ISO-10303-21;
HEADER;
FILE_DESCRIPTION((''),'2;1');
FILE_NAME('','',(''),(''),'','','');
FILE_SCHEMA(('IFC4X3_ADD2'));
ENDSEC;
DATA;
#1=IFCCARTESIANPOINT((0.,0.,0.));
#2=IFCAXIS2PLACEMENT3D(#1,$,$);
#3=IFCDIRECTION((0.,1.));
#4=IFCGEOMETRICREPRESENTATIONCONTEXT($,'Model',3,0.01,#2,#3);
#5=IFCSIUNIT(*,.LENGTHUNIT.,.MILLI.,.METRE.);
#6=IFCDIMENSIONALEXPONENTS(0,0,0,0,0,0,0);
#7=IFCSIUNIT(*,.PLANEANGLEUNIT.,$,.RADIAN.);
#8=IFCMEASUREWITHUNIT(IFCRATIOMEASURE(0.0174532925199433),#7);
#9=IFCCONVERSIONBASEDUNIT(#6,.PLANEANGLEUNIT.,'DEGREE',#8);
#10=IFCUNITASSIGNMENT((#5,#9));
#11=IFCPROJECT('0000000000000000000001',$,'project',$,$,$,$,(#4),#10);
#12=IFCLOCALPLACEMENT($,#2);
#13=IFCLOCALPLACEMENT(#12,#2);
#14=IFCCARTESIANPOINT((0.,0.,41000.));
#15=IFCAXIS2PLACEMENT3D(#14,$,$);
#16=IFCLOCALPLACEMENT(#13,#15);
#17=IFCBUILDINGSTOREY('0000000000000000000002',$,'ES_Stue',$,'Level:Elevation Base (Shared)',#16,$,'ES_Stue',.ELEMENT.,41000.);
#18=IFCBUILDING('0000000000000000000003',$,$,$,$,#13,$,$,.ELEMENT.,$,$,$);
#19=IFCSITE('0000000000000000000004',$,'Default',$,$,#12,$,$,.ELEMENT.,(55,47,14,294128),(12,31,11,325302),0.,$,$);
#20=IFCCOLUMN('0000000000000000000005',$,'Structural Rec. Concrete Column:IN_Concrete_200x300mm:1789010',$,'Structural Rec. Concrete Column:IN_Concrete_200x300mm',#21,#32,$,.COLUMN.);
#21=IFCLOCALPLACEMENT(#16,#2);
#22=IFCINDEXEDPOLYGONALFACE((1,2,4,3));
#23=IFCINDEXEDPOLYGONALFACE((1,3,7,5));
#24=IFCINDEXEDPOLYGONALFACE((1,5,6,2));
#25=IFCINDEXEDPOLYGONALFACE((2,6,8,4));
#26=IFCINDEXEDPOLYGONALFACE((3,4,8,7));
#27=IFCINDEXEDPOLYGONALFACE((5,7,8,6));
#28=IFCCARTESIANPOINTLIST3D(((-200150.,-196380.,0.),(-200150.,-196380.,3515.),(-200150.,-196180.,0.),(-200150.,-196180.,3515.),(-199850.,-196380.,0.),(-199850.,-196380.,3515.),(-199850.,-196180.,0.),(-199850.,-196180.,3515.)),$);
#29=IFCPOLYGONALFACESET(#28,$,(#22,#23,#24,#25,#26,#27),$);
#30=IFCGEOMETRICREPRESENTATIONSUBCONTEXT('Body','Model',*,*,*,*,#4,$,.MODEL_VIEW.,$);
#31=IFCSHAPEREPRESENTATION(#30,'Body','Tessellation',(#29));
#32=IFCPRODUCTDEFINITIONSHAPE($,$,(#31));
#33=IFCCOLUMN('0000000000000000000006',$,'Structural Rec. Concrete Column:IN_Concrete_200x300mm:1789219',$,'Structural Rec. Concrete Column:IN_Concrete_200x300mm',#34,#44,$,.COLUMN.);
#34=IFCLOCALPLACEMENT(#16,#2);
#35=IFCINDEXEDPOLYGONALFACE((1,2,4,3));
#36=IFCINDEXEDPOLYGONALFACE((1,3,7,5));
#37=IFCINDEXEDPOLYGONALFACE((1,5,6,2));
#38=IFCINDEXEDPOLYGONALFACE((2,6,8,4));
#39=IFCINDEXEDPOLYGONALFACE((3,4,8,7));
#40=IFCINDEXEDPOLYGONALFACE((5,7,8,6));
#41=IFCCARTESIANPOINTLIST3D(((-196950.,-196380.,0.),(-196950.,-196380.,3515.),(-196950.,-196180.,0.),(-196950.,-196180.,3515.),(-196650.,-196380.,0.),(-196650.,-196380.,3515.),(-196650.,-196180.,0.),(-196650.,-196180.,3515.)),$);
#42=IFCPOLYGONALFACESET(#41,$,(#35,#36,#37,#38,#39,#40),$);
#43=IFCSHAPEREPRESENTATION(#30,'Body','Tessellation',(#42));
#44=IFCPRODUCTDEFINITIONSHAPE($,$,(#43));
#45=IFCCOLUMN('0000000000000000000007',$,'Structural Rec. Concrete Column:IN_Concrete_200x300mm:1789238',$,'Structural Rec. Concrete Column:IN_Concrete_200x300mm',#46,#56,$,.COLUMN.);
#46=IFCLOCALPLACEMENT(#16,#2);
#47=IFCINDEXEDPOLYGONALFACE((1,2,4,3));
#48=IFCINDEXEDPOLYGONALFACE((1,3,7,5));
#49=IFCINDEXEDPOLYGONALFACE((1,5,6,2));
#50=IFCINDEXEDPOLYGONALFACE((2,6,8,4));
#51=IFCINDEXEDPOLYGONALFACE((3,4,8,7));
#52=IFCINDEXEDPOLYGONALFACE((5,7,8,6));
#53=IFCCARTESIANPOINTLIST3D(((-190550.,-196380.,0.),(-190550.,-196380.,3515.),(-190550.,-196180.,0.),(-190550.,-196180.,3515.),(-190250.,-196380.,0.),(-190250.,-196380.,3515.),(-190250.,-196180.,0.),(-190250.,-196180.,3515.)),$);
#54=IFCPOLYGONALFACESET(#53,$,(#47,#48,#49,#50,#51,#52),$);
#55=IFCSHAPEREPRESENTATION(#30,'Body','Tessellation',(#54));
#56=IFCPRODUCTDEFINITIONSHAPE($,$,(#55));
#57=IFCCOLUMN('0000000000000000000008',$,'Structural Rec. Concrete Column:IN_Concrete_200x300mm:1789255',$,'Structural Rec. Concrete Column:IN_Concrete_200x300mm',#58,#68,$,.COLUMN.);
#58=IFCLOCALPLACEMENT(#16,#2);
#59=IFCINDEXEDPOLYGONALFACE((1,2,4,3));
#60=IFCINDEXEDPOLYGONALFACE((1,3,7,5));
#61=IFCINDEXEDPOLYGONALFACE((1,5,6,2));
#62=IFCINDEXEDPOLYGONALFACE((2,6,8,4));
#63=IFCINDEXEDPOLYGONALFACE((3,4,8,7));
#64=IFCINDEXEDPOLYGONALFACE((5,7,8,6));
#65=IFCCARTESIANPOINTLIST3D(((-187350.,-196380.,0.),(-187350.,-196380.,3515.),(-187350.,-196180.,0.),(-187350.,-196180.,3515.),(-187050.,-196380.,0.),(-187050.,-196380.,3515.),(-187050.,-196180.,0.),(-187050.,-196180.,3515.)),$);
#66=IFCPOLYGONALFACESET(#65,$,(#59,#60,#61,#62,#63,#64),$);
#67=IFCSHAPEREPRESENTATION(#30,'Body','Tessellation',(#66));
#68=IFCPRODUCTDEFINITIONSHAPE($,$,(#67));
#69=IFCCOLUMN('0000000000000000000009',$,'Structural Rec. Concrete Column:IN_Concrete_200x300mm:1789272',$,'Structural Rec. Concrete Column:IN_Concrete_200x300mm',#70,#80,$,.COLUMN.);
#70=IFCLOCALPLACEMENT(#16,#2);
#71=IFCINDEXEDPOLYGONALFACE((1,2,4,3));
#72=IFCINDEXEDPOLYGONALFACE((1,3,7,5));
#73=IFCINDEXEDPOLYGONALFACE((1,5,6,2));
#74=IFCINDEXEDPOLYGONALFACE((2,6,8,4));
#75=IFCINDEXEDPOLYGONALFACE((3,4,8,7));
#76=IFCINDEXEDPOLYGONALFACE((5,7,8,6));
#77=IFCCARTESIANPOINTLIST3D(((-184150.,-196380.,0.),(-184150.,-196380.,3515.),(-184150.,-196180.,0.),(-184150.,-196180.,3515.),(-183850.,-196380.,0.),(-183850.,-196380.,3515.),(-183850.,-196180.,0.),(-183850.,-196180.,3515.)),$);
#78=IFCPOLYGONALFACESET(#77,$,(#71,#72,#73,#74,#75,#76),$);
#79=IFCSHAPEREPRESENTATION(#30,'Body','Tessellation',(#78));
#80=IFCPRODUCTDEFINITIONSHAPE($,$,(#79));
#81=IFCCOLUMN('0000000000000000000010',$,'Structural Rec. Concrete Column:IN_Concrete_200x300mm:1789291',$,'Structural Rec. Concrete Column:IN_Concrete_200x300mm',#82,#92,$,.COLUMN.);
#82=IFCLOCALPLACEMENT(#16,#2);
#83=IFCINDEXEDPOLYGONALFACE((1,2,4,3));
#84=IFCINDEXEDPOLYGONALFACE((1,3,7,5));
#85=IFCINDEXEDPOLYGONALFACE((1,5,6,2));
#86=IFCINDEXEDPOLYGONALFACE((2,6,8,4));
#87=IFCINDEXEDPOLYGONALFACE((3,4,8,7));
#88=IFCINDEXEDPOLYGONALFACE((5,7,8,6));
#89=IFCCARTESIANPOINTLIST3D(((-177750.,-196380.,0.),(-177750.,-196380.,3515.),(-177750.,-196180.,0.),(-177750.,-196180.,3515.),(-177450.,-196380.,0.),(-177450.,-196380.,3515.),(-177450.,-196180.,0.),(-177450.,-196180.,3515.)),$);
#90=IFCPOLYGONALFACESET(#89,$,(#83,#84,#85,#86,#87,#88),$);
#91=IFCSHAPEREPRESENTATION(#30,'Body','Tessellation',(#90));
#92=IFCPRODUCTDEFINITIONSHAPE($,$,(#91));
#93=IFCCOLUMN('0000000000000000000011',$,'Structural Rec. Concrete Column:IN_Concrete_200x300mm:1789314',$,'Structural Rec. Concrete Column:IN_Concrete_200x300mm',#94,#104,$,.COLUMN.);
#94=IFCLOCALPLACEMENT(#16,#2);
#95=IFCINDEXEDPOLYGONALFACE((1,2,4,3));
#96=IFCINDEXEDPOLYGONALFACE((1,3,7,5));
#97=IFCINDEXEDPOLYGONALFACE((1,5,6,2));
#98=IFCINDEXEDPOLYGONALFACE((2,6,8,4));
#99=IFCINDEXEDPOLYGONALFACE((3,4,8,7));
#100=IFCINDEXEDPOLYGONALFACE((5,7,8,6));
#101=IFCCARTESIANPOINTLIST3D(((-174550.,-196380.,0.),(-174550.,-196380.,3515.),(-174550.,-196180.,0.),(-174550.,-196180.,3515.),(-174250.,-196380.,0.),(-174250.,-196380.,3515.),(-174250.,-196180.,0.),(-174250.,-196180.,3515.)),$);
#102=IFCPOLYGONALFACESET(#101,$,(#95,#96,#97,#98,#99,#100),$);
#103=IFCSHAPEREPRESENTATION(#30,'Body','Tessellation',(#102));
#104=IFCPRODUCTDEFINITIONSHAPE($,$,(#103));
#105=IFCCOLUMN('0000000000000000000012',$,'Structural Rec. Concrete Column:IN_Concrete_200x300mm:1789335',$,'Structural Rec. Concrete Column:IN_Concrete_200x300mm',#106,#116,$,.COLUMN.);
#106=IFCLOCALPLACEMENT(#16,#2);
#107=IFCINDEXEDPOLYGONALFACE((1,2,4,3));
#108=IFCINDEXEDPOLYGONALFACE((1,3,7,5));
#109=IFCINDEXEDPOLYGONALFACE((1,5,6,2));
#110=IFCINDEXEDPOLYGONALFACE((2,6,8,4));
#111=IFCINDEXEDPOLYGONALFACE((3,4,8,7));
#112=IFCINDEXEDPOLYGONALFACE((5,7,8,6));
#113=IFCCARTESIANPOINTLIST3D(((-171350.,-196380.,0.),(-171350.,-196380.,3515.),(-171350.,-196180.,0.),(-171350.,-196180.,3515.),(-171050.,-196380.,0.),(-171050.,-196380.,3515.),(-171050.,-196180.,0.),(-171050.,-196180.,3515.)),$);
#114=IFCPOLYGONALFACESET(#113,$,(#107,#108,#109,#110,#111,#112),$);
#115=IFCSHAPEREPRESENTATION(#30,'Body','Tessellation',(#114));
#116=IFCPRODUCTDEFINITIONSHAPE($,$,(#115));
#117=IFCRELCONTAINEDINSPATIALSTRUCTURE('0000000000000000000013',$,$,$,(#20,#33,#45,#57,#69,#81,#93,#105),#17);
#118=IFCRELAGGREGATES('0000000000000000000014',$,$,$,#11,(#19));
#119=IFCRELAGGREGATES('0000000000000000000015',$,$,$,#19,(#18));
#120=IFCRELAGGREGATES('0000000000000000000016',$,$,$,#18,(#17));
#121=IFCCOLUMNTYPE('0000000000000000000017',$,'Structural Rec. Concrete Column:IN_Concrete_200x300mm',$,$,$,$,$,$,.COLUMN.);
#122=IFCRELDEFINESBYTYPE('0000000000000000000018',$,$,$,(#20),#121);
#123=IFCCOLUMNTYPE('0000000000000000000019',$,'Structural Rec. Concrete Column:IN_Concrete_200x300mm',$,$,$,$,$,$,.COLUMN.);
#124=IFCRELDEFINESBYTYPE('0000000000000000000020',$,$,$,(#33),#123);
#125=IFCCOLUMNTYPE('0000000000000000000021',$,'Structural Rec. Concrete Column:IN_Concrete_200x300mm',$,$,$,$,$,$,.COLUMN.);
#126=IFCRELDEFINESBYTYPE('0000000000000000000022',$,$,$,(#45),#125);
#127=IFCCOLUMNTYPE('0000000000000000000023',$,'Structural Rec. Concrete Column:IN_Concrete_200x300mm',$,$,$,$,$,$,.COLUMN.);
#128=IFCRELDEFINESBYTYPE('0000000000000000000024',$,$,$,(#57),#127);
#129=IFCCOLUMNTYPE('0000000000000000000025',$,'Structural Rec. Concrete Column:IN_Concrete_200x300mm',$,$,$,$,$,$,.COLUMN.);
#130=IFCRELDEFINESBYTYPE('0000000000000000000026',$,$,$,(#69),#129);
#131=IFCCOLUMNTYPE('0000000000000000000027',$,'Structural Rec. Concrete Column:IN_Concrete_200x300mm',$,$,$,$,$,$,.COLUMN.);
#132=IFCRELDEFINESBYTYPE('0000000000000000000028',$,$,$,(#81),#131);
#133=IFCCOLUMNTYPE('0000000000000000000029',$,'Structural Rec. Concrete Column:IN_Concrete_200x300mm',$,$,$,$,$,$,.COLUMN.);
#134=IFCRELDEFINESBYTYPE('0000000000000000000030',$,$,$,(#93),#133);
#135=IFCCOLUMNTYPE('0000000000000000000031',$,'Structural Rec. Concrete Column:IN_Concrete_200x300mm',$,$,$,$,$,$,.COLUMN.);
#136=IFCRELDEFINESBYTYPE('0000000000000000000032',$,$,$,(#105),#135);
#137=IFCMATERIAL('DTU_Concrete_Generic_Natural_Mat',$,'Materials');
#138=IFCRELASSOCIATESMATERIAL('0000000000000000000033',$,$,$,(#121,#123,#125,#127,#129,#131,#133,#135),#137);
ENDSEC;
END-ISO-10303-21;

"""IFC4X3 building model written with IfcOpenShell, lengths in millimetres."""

from ifc_helpers import new_model, entity, si_unit, converted_unit, direction, frame, origin, origin_2d_with_axis, place, context, subcontext, project, spatial, rectangle, extrude, source, transform, mapped, material, material_profile, profile_set, type_object, type_shapes, element, save


model = new_model("IFC4X3")

# Units and contexts
model_context = context("Model", 3, precision=0.01, world=origin(), true_north=direction((0.0, 1.0)))
body_context = subcontext(model_context, "Body", "Model", "MODEL_VIEW")
ifc_project = project(units=[si_unit("LENGTHUNIT", "METRE", prefix="MILLI"), converted_unit("PLANEANGLEUNIT", "DEGREE", entity("IfcRatioMeasure", 0.0174532925199433), si_unit("PLANEANGLEUNIT", "RADIAN"), dimensions=[0, 0, 0, 0, 0, 0, 0])], contexts=[model_context])

# Site, building, storey
site_placement = place(None, origin())
site = spatial("IfcSite", under=ifc_project, at=site_placement, Name="Default", CompositionType="ELEMENT", RefLatitude=(55, 47, 14, 294128), RefLongitude=(12, 31, 11, 325302), RefElevation=0.0)
building_placement = place(site_placement, origin())
building = spatial("IfcBuilding", under=site, at=building_placement, CompositionType="ELEMENT")
storey_placement = place(building_placement, frame((0.0, 0.0, 41000.0)))
storey = spatial("IfcBuildingStorey", under=building, at=storey_placement, Name="ES_Stue", ObjectType="Level:Elevation Base (Shared)", LongName="ES_Stue", CompositionType="ELEMENT", Elevation=41000.0)

# Columns
ifc_material = material(Name="DTU_Concrete_Generic_Natural_Mat", Category="Materials")
ifc_material_profile_1 = material_profile(ifc_material, rectangle(XDim=200.0, YDim=300.0, at=origin_2d_with_axis()), Name="IN_Concrete_200x300mm")
ifc_profile_set_1 = profile_set([ifc_material_profile_1], Name="IN_Concrete_200x300mm")
column_type_1 = type_object("IfcColumnType", Name="Structural Rec. Concrete Column:IN_Concrete_200x300mm", PredefinedType="COLUMN", material=ifc_profile_set_1)
shared_shape_1 = source(origin(), body_context, "Body", "SweptSolid", [
    extrude(rectangle(XDim=200.0, YDim=300.0, at=origin_2d_with_axis()), frame((-200000.0, -196280.0, 41000.0), z_axis=(0.0, 0.0, 1.0), x_axis=(0.0, -1.0, 0.0)), (0.0, 0.0, 1.0), 3515.0),
])
type_shapes(column_type_1, [shared_shape_1])
column_1_placement = place(storey_placement, frame((0.0, 0.0, -41000.0)))
element("IfcColumn", 1, at=column_1_placement, inside=storey, type_object=column_type_1, Name="Structural Rec. Concrete Column:IN_Concrete_200x300mm:1789010", ObjectType="Structural Rec. Concrete Column:IN_Concrete_200x300mm", PredefinedType="COLUMN", context=body_context, shape_type="MappedRepresentation", body=[
    mapped(shared_shape_1, transform((0.0, 0.0, 0.0), scale=1.0)),
])
column_type_2 = type_object("IfcColumnType", Name="Structural Rec. Concrete Column:IN_Concrete_200x300mm", PredefinedType="COLUMN", material=ifc_profile_set_1)
shared_shape_2 = source(origin(), body_context, "Body", "SweptSolid", [
    extrude(rectangle(XDim=200.0, YDim=300.0, at=origin_2d_with_axis()), frame((-196800.0, -196280.0, 41000.0), z_axis=(0.0, 0.0, 1.0), x_axis=(0.0, -1.0, 0.0)), (0.0, 0.0, 1.0), 3515.0),
])
type_shapes(column_type_2, [shared_shape_2])
column_2_placement = place(storey_placement, frame((0.0, 0.0, -41000.0)))
element("IfcColumn", 2, at=column_2_placement, inside=storey, type_object=column_type_2, Name="Structural Rec. Concrete Column:IN_Concrete_200x300mm:1789219", ObjectType="Structural Rec. Concrete Column:IN_Concrete_200x300mm", PredefinedType="COLUMN", context=body_context, shape_type="MappedRepresentation", body=[
    mapped(shared_shape_2, transform((0.0, 0.0, 0.0), scale=1.0)),
])
column_type_3 = type_object("IfcColumnType", Name="Structural Rec. Concrete Column:IN_Concrete_200x300mm", PredefinedType="COLUMN", material=ifc_profile_set_1)
shared_shape_3 = source(origin(), body_context, "Body", "SweptSolid", [
    extrude(rectangle(XDim=200.0, YDim=300.0, at=origin_2d_with_axis()), frame((-190400.0, -196280.0, 41000.0), z_axis=(0.0, 0.0, 1.0), x_axis=(0.0, -1.0, 0.0)), (0.0, 0.0, 1.0), 3515.0),
])
type_shapes(column_type_3, [shared_shape_3])
column_3_placement = place(storey_placement, frame((0.0, 0.0, -41000.0)))
element("IfcColumn", 3, at=column_3_placement, inside=storey, type_object=column_type_3, Name="Structural Rec. Concrete Column:IN_Concrete_200x300mm:1789238", ObjectType="Structural Rec. Concrete Column:IN_Concrete_200x300mm", PredefinedType="COLUMN", context=body_context, shape_type="MappedRepresentation", body=[
    mapped(shared_shape_3, transform((0.0, 0.0, 0.0), scale=1.0)),
])
column_type_4 = type_object("IfcColumnType", Name="Structural Rec. Concrete Column:IN_Concrete_200x300mm", PredefinedType="COLUMN", material=ifc_profile_set_1)
shared_shape_4 = source(origin(), body_context, "Body", "SweptSolid", [
    extrude(rectangle(XDim=200.0, YDim=300.0, at=origin_2d_with_axis()), frame((-187200.0, -196280.0, 41000.0), z_axis=(0.0, 0.0, 1.0), x_axis=(0.0, -1.0, 0.0)), (0.0, 0.0, 1.0), 3515.0),
])
type_shapes(column_type_4, [shared_shape_4])
column_4_placement = place(storey_placement, frame((0.0, 0.0, -41000.0)))
element("IfcColumn", 4, at=column_4_placement, inside=storey, type_object=column_type_4, Name="Structural Rec. Concrete Column:IN_Concrete_200x300mm:1789255", ObjectType="Structural Rec. Concrete Column:IN_Concrete_200x300mm", PredefinedType="COLUMN", context=body_context, shape_type="MappedRepresentation", body=[
    mapped(shared_shape_4, transform((0.0, 0.0, 0.0), scale=1.0)),
])
column_type_5 = type_object("IfcColumnType", Name="Structural Rec. Concrete Column:IN_Concrete_200x300mm", PredefinedType="COLUMN", material=ifc_profile_set_1)
shared_shape_5 = source(origin(), body_context, "Body", "SweptSolid", [
    extrude(rectangle(XDim=200.0, YDim=300.0, at=origin_2d_with_axis()), frame((-184000.0, -196280.0, 41000.0), z_axis=(0.0, 0.0, 1.0), x_axis=(0.0, -1.0, 0.0)), (0.0, 0.0, 1.0), 3515.0),
])
type_shapes(column_type_5, [shared_shape_5])
column_5_placement = place(storey_placement, frame((0.0, 0.0, -41000.0)))
element("IfcColumn", 5, at=column_5_placement, inside=storey, type_object=column_type_5, Name="Structural Rec. Concrete Column:IN_Concrete_200x300mm:1789272", ObjectType="Structural Rec. Concrete Column:IN_Concrete_200x300mm", PredefinedType="COLUMN", context=body_context, shape_type="MappedRepresentation", body=[
    mapped(shared_shape_5, transform((0.0, 0.0, 0.0), scale=1.0)),
])
column_type_6 = type_object("IfcColumnType", Name="Structural Rec. Concrete Column:IN_Concrete_200x300mm", PredefinedType="COLUMN", material=ifc_profile_set_1)
shared_shape_6 = source(origin(), body_context, "Body", "SweptSolid", [
    extrude(rectangle(XDim=200.0, YDim=300.0, at=origin_2d_with_axis()), frame((-177600.0, -196280.0, 41000.0), z_axis=(0.0, 0.0, 1.0), x_axis=(0.0, -1.0, 0.0)), (0.0, 0.0, 1.0), 3515.0),
])
type_shapes(column_type_6, [shared_shape_6])
column_6_placement = place(storey_placement, frame((0.0, 0.0, -41000.0)))
element("IfcColumn", 6, at=column_6_placement, inside=storey, type_object=column_type_6, Name="Structural Rec. Concrete Column:IN_Concrete_200x300mm:1789291", ObjectType="Structural Rec. Concrete Column:IN_Concrete_200x300mm", PredefinedType="COLUMN", context=body_context, shape_type="MappedRepresentation", body=[
    mapped(shared_shape_6, transform((0.0, 0.0, 0.0), scale=1.0)),
])
column_type_7 = type_object("IfcColumnType", Name="Structural Rec. Concrete Column:IN_Concrete_200x300mm", PredefinedType="COLUMN", material=ifc_profile_set_1)
shared_shape_7 = source(origin(), body_context, "Body", "SweptSolid", [
    extrude(rectangle(XDim=200.0, YDim=300.0, at=origin_2d_with_axis()), frame((-174400.0, -196280.0, 41000.0), z_axis=(0.0, 0.0, 1.0), x_axis=(0.0, -1.0, 0.0)), (0.0, 0.0, 1.0), 3515.0),
])
type_shapes(column_type_7, [shared_shape_7])
column_7_placement = place(storey_placement, frame((0.0, 0.0, -41000.0)))
element("IfcColumn", 7, at=column_7_placement, inside=storey, type_object=column_type_7, Name="Structural Rec. Concrete Column:IN_Concrete_200x300mm:1789314", ObjectType="Structural Rec. Concrete Column:IN_Concrete_200x300mm", PredefinedType="COLUMN", context=body_context, shape_type="MappedRepresentation", body=[
    mapped(shared_shape_7, transform((0.0, 0.0, 0.0), scale=1.0)),
])
column_type_8 = type_object("IfcColumnType", Name="Structural Rec. Concrete Column:IN_Concrete_200x300mm", PredefinedType="COLUMN", material=ifc_profile_set_1)
shared_shape_8 = source(origin(), body_context, "Body", "SweptSolid", [
    extrude(rectangle(XDim=200.0, YDim=300.0, at=origin_2d_with_axis()), frame((-171200.0, -196280.0, 41000.0), z_axis=(0.0, 0.0, 1.0), x_axis=(0.0, -1.0, 0.0)), (0.0, 0.0, 1.0), 3515.0),
])
type_shapes(column_type_8, [shared_shape_8])
column_8_placement = place(storey_placement, frame((0.0, 0.0, -41000.0)))
element("IfcColumn", 8, at=column_8_placement, inside=storey, type_object=column_type_8, Name="Structural Rec. Concrete Column:IN_Concrete_200x300mm:1789335", ObjectType="Structural Rec. Concrete Column:IN_Concrete_200x300mm", PredefinedType="COLUMN", context=body_context, shape_type="MappedRepresentation", body=[
    mapped(shared_shape_8, transform((0.0, 0.0, 0.0), scale=1.0)),
])

save(model, "model.ifc")
